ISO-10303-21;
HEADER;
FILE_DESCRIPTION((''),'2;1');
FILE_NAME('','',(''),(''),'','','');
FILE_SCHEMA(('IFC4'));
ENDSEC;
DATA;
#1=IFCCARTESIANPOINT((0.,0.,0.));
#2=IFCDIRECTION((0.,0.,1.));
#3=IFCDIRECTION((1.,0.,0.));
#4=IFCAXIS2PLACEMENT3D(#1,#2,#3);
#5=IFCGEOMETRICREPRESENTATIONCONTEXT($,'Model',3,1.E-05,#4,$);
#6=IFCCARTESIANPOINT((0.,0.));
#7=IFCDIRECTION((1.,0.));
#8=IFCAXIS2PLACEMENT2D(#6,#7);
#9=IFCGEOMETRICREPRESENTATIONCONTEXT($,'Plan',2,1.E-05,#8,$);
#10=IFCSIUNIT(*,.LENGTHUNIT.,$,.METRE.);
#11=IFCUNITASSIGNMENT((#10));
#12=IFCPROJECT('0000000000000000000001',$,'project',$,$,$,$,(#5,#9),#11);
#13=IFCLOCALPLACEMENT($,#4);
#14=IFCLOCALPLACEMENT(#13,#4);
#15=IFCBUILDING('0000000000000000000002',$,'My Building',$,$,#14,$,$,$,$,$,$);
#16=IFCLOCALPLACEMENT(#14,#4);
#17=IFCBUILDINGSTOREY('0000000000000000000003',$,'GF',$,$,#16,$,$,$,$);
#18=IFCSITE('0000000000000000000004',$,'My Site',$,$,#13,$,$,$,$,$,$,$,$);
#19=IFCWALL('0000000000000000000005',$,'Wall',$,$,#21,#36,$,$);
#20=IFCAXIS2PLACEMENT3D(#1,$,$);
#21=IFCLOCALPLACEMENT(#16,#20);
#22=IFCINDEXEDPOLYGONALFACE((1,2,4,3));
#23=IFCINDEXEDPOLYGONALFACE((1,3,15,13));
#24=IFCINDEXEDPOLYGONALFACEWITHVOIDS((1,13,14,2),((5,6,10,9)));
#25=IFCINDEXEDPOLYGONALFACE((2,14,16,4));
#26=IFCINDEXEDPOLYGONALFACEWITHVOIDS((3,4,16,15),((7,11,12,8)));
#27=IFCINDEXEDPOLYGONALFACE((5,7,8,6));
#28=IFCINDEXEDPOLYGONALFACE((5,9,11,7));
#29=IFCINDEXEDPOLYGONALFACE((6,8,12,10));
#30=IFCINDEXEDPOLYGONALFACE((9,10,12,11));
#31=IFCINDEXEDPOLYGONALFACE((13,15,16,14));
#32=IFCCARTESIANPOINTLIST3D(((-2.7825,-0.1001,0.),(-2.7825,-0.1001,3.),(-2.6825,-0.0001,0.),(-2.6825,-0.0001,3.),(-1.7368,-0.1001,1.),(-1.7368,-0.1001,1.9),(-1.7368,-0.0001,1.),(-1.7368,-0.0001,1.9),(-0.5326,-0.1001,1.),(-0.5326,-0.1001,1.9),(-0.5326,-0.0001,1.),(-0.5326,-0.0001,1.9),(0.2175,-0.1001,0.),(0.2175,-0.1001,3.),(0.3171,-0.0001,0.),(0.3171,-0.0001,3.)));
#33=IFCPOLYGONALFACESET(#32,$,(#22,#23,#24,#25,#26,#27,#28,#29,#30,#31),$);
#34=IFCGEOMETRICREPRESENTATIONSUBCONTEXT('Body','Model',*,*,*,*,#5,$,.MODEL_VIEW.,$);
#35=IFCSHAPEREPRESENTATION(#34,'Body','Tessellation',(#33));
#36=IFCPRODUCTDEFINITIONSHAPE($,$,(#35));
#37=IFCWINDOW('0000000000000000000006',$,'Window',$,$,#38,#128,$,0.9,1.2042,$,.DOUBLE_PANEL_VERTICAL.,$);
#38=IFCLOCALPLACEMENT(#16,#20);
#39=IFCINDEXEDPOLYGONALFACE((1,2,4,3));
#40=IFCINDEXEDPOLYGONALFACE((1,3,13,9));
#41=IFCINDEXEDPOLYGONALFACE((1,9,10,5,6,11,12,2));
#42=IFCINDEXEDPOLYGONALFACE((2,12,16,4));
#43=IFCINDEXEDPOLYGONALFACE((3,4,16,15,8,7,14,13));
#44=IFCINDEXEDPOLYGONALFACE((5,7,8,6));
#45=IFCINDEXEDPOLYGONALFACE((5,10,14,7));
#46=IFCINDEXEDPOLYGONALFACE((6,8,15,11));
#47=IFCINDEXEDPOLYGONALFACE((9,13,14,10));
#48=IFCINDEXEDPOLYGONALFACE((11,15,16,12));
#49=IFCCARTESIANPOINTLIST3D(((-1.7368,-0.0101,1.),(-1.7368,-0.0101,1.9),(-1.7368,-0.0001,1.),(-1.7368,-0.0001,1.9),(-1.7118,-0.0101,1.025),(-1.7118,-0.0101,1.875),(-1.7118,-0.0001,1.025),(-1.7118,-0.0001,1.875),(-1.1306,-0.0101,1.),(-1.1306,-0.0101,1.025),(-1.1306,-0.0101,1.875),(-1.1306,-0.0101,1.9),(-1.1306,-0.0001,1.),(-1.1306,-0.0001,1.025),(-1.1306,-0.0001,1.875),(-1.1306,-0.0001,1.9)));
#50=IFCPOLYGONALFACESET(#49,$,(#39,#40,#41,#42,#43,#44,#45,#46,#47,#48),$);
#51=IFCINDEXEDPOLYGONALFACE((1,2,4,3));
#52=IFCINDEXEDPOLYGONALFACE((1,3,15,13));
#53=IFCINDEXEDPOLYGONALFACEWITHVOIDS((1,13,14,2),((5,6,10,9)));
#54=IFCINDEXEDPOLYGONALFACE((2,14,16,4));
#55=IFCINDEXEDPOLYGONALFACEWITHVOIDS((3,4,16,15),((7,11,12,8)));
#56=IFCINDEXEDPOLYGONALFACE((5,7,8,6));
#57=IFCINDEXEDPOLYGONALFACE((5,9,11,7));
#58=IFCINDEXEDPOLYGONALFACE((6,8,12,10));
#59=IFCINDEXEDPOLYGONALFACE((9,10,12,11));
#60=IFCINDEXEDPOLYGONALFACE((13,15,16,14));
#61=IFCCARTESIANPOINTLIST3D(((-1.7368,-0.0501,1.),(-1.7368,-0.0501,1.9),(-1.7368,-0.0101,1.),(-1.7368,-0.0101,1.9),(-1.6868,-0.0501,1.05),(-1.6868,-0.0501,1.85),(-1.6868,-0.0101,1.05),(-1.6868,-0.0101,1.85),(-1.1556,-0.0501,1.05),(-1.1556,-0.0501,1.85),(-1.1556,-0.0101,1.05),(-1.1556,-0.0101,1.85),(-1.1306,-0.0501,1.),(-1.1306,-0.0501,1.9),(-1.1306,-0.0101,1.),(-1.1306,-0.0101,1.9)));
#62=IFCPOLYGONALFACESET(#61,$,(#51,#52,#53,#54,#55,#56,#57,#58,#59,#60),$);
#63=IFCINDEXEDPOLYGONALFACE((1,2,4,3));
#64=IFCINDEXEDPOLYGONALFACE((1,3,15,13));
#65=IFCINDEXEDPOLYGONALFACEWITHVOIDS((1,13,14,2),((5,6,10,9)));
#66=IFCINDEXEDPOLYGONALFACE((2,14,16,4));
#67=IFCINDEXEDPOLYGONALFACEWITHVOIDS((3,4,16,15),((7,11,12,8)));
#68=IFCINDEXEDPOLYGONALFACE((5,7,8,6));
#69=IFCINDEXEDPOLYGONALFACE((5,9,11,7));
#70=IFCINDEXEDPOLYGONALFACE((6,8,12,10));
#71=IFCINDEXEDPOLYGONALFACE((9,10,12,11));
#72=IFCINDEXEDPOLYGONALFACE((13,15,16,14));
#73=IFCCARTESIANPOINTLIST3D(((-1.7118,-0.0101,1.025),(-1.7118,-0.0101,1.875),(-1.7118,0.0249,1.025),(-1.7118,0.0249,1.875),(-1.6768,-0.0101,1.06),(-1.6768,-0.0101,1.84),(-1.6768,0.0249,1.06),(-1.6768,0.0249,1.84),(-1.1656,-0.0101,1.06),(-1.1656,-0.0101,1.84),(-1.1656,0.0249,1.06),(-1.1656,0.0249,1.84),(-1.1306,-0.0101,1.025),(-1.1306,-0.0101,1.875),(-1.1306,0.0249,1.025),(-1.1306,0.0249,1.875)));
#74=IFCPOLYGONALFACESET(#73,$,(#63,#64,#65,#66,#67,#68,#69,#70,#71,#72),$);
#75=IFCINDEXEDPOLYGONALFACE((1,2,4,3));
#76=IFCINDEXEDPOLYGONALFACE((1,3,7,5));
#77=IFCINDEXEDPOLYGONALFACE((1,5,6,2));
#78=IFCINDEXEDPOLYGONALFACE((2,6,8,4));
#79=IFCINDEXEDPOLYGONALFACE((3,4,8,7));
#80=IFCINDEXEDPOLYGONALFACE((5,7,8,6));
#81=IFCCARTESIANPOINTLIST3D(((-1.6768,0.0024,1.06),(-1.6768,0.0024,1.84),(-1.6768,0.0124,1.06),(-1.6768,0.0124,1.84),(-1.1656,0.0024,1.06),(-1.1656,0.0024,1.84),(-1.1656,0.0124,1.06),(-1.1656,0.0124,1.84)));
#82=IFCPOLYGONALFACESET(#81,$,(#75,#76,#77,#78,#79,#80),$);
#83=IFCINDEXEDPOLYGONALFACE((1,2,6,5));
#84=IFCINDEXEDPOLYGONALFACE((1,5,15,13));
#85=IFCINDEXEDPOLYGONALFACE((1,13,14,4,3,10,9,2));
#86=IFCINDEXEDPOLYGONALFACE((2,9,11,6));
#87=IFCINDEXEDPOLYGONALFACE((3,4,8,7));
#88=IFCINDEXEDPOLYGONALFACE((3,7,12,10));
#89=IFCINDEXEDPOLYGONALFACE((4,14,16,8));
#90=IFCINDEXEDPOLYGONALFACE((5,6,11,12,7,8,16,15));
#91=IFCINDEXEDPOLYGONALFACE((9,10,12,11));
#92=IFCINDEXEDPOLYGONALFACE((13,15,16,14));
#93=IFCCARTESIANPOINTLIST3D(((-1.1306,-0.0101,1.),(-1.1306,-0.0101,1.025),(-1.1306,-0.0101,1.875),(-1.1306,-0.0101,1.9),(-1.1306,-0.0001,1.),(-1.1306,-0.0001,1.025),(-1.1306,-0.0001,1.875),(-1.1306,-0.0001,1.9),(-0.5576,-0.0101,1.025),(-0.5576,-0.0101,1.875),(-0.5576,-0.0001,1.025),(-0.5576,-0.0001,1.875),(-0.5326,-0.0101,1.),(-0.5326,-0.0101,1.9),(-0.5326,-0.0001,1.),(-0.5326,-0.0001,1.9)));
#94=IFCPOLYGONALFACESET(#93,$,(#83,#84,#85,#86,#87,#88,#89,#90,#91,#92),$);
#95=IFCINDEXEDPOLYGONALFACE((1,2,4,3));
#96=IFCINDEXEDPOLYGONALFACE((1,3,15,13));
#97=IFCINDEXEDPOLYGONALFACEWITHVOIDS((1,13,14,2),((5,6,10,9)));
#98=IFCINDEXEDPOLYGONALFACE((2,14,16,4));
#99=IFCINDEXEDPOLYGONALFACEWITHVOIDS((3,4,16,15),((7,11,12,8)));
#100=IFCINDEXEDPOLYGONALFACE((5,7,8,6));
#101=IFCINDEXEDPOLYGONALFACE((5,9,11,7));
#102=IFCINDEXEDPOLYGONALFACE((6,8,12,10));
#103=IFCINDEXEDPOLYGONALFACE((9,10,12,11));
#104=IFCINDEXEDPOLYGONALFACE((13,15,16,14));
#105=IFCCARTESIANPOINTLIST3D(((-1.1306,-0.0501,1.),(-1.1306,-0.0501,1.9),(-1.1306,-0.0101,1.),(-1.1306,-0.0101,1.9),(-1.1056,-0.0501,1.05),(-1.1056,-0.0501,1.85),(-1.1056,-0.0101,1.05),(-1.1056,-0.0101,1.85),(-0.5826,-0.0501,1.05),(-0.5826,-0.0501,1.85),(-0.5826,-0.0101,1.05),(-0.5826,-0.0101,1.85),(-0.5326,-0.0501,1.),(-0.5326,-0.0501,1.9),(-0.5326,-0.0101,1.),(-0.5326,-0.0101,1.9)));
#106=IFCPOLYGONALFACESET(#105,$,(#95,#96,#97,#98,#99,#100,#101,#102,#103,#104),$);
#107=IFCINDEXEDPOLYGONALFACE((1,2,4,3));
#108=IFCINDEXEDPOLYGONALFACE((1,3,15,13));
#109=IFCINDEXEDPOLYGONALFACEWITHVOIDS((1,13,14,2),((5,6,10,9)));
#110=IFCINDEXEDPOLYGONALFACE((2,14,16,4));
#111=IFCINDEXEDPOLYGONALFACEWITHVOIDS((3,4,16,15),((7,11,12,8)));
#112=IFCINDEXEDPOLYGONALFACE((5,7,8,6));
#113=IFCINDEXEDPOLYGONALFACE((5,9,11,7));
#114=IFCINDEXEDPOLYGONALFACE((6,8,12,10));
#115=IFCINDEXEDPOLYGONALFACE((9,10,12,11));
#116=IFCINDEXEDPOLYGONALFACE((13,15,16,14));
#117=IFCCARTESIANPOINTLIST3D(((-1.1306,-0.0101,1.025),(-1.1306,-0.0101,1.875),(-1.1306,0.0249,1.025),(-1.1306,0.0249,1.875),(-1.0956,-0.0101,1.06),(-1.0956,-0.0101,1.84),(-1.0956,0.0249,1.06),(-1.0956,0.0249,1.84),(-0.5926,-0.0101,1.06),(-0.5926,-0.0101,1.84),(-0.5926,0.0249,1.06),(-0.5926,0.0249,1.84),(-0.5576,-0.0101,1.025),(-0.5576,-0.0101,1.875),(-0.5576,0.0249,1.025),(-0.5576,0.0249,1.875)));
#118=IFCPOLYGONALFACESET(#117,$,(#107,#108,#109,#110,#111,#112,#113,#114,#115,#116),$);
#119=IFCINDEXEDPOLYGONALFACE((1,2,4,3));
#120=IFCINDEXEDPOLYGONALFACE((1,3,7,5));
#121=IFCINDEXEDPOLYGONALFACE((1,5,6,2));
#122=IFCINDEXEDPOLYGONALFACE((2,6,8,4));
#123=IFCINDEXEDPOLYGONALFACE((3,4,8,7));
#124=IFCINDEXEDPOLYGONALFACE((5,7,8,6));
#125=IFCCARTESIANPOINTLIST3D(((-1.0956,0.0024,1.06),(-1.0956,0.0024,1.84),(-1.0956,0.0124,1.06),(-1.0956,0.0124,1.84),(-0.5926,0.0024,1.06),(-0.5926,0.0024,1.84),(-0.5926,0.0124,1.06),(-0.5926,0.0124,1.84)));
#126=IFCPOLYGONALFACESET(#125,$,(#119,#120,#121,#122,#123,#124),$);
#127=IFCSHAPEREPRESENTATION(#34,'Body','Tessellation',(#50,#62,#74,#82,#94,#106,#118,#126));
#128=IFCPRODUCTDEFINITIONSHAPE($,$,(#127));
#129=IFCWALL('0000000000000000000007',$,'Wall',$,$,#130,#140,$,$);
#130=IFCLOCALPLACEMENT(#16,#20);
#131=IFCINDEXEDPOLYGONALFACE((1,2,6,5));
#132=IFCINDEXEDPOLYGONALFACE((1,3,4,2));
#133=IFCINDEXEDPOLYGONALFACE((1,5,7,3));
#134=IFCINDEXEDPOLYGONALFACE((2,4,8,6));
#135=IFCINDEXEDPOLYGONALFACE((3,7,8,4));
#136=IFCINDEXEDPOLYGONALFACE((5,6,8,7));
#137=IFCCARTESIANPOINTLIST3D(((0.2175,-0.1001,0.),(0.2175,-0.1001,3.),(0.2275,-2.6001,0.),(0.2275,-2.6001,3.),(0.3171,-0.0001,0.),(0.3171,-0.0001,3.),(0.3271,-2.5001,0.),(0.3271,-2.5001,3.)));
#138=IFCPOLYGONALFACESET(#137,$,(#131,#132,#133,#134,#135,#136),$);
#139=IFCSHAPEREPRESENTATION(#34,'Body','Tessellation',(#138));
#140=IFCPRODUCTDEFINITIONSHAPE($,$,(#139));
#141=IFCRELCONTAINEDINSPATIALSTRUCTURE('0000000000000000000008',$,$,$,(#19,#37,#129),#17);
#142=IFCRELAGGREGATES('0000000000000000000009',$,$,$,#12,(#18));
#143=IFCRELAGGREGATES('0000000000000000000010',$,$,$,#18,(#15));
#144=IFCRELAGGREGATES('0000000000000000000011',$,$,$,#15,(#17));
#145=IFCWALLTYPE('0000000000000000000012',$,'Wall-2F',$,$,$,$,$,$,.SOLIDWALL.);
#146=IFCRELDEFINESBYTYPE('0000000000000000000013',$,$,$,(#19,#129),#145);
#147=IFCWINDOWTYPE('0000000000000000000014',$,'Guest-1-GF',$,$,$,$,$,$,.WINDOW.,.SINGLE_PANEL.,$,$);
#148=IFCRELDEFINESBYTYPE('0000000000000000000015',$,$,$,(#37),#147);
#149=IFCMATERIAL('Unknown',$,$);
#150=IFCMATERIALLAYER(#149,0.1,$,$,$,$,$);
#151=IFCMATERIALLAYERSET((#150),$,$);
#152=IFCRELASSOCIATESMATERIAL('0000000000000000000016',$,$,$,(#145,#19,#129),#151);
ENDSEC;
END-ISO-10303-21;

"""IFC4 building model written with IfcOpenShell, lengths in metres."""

from ifc_helpers import new_model, entity, si_unit, frame, origin_with_axes, origin_2d_with_axis, place, context, subcontext, project, spatial, line, indexed_curve, outline, extrude, shape, source, transform, mapped, material, layer, layer_set, layer_usage, type_object, type_shapes, element, fill, save


model = new_model("IFC4")

# Units and contexts
model_context = context("Model", 3, precision=1e-05, world=origin_with_axes())
plan_context = context("Plan", 2, precision=1e-05, world=origin_2d_with_axis())
body_context_1 = subcontext(model_context, "Body", "Model", "MODEL_VIEW")
body_context_2 = subcontext(plan_context, "Body", "Plan", "PLAN_VIEW")
ifc_project = project(units=[si_unit("LENGTHUNIT", "METRE")], contexts=[model_context, plan_context])

# Site, building, storey
site_placement = place(None, origin_with_axes())
site = spatial("IfcSite", under=ifc_project, at=site_placement, Name="My Site")
building_placement = place(site_placement, origin_with_axes())
building = spatial("IfcBuilding", under=site, at=building_placement, Name="My Building")
storey_placement = place(building_placement, origin_with_axes())
storey = spatial("IfcBuildingStorey", under=building, at=storey_placement, Name="GF")

# Shared definitions
ifc_material_1 = material(Name="Unknown")

# Shared definitions
ifc_layer_1 = layer(ifc_material_1, 0.1)
ifc_layer_set_1 = layer_set([ifc_layer_1])
wall_type = type_object("IfcWallType", Name="Wall-2F", PredefinedType="SOLIDWALL", material=ifc_layer_set_1)

# Wall, opening, window
ifc_layer_usage_1 = layer_usage(ifc_layer_set_1, "AXIS2", "POSITIVE", 0.0)
wall_1_placement = place(storey_placement, frame((-2.7825, -0.1001, 0.0), z_axis=(0.0, 0.0, 1.0), x_axis=(1.0, 0.0, 0.0)))
wall_1 = element("IfcWall", 1, at=wall_1_placement, inside=storey, type_object=wall_type, material=ifc_layer_usage_1, Name="Wall", context=body_context_1, shape_type="SweptSolid", body=[
    extrude(outline(indexed_curve([(0.0, 0.0), (0.1, 0.1), (3.0996, 0.1), (3.0, 0.0)], segments=[line(1, 2, 3, 4, 1)])), origin_with_axes(), (0.0, 0.0, 1.0), 3.0),
])
shared_shape_1 = source(origin_with_axes(), body_context_1, "Body", "SweptSolid", [
    extrude(outline(indexed_curve([(0.0, 0.0), (1.2042, 0.0), (1.2042, 0.9), (0.0, 0.9)], segments=[line(1, 2, 3, 4, 1)])), frame((0.0, -0.6, 0.0), z_axis=(0.0, -1.0, 0.0), x_axis=(1.0, 0.0, 0.0)), (0.0, 0.0, -1.0), 1.2),
])
opening_1_placement = place(wall_1_placement, frame((1.0457, 0.0, 1.0), z_axis=(0.0, 0.0, 1.0), x_axis=(1.0, 0.0, 0.0)))
opening_1 = element("IfcOpeningElement", 2, at=opening_1_placement, cuts=wall_1, PredefinedType="OPENING", context=body_context_1, shape_type="MappedRepresentation", body=[
    mapped(shared_shape_1, transform((0.0, 0.0, 0.0), x_axis=(1.0, 0.0, 0.0), y_axis=(0.0, 1.0, 0.0), z_axis=(0.0, 0.0, 1.0), scale=1.0)),
])
window_type_1 = type_object("IfcWindowType", Name="Guest-1-GF", PartitioningType="SINGLE_PANEL", PredefinedType="WINDOW")
shared_shape_2 = source(origin_with_axes(), body_context_1, "Body", "SweptSolid", [
    extrude(outline(indexed_curve([(0.6062, 0.0), (0.0, 0.0), (0.0, 0.9), (0.6062, 0.9), (0.6062, 0.875), (0.025, 0.875), (0.025, 0.025), (0.6062, 0.025)], segments=[line(1, 2, 3, 4, 5, 6, 7, 8, 1)])), frame((0.0, 0.09, 0.0), z_axis=(0.0, -1.0, 0.0), x_axis=(1.0, 0.0, 0.0)), (0.0, 0.0, -1.0), 0.01),
    extrude(outline(indexed_curve([(0.0, 0.0), (0.6062, 0.0), (0.6062, 0.9), (0.0, 0.9)], segments=[line(1, 2, 3, 4, 1)]), holes=[indexed_curve([(0.05, 0.05), (0.5812, 0.05), (0.5812, 0.85), (0.05, 0.85)], segments=[line(1, 2, 3, 4, 1)])]), frame((0.0, 0.05, 0.0), z_axis=(0.0, -1.0, 0.0), x_axis=(1.0, 0.0, 0.0)), (0.0, 0.0, -1.0), 0.04),
    extrude(outline(indexed_curve([(0.0, 0.0), (0.5812, 0.0), (0.5812, 0.85), (0.0, 0.85)], segments=[line(1, 2, 3, 4, 1)]), holes=[indexed_curve([(0.035, 0.035), (0.5462, 0.035), (0.5462, 0.815), (0.035, 0.815)], segments=[line(1, 2, 3, 4, 1)])]), frame((0.025, 0.09, 0.025), z_axis=(0.0, -1.0, 0.0), x_axis=(1.0, 0.0, 0.0)), (0.0, 0.0, -1.0), 0.035),
    extrude(outline(indexed_curve([(0.035, 0.035), (0.5462, 0.035), (0.5462, 0.815), (0.035, 0.815)], segments=[line(1, 2, 3, 4, 1)])), frame((0.025, 0.1025, 0.025), z_axis=(0.0, -1.0, 0.0), x_axis=(1.0, 0.0, 0.0)), (0.0, 0.0, -1.0), 0.01),
    extrude(outline(indexed_curve([(0.0, 0.9), (0.598, 0.9), (0.598, 0.0), (0.0, 0.0), (0.0, 0.025), (0.573, 0.025), (0.573, 0.875), (0.0, 0.875)], segments=[line(1, 2, 3, 4, 5, 6, 7, 8, 1)])), frame((0.6062, 0.09, 0.0), z_axis=(0.0, -1.0, 0.0), x_axis=(1.0, 0.0, 0.0)), (0.0, 0.0, -1.0), 0.01),
    extrude(outline(indexed_curve([(0.0, 0.0), (0.598, 0.0), (0.598, 0.9), (0.0, 0.9)], segments=[line(1, 2, 3, 4, 1)]), holes=[indexed_curve([(0.025, 0.05), (0.548, 0.05), (0.548, 0.85), (0.025, 0.85)], segments=[line(1, 2, 3, 4, 1)])]), frame((0.6062, 0.05, 0.0), z_axis=(0.0, -1.0, 0.0), x_axis=(1.0, 0.0, 0.0)), (0.0, 0.0, -1.0), 0.04),
    extrude(outline(indexed_curve([(0.0, 0.0), (0.573, 0.0), (0.573, 0.85), (0.0, 0.85)], segments=[line(1, 2, 3, 4, 1)]), holes=[indexed_curve([(0.035, 0.035), (0.538, 0.035), (0.538, 0.815), (0.035, 0.815)], segments=[line(1, 2, 3, 4, 1)])]), frame((0.6062, 0.09, 0.025), z_axis=(0.0, -1.0, 0.0), x_axis=(1.0, 0.0, 0.0)), (0.0, 0.0, -1.0), 0.035),
    extrude(outline(indexed_curve([(0.035, 0.035), (0.538, 0.035), (0.538, 0.815), (0.035, 0.815)], segments=[line(1, 2, 3, 4, 1)])), frame((0.6062, 0.1025, 0.025), z_axis=(0.0, -1.0, 0.0), x_axis=(1.0, 0.0, 0.0)), (0.0, 0.0, -1.0), 0.01),
])
shared_shape_3 = source(origin_with_axes(), body_context_2, "Body", "Curve2D", [
    entity("IfcIndexedPolyCurve", entity("IfcCartesianPointList2D", [[0.05, 0.05], [0.5812, 0.05]])),
    entity("IfcIndexedPolyCurve", entity("IfcCartesianPointList2D", [[0.0, 0.1], [0.025, 0.1], [0.025, 0.09], [0.05, 0.09], [0.05, 0.05], [0.0, 0.05]]), [entity("IfcLineIndex", [1, 2, 3, 4, 5, 6, 1])]),
    entity("IfcIndexedPolyCurve", entity("IfcCartesianPointList2D", [[0.6062, 0.1], [0.6062, 0.1], [0.6062, 0.09], [0.5812, 0.09], [0.5812, 0.05], [0.6062, 0.05]])),
    entity("IfcIndexedPolyCurve", entity("IfcCartesianPointList2D", [[0.025, 0.09], [0.06, 0.09], [0.06, 0.125], [0.025, 0.125]]), [entity("IfcLineIndex", [1, 2, 3, 4, 1])]),
    entity("IfcIndexedPolyCurve", entity("IfcCartesianPointList2D", [[0.6062, 0.09], [0.5712, 0.09], [0.5712, 0.125], [0.6062, 0.125]]), [entity("IfcLineIndex", [1, 2, 3, 4, 1])]),
    entity("IfcIndexedPolyCurve", entity("IfcCartesianPointList2D", [[0.06, 0.09], [0.5712, 0.09]])),
    entity("IfcIndexedPolyCurve", entity("IfcCartesianPointList2D", [[0.06, 0.125], [0.5712, 0.125]])),
    entity("IfcIndexedPolyCurve", entity("IfcCartesianPointList2D", [[0.06, 0.1075], [0.5712, 0.1075]])),
    entity("IfcIndexedPolyCurve", entity("IfcCartesianPointList2D", [[0.6312, 0.05], [1.1542, 0.05]])),
    entity("IfcIndexedPolyCurve", entity("IfcCartesianPointList2D", [[0.6062, 0.1], [0.6062, 0.1], [0.6062, 0.09], [0.6312, 0.09], [0.6312, 0.05], [0.6062, 0.05]])),
    entity("IfcIndexedPolyCurve", entity("IfcCartesianPointList2D", [[1.2042, 0.1], [1.1792, 0.1], [1.1792, 0.09], [1.1542, 0.09], [1.1542, 0.05], [1.2042, 0.05]]), [entity("IfcLineIndex", [1, 2, 3, 4, 5, 6, 1])]),
    entity("IfcIndexedPolyCurve", entity("IfcCartesianPointList2D", [[0.6062, 0.09], [0.6412, 0.09], [0.6412, 0.125], [0.6062, 0.125]]), [entity("IfcLineIndex", [1, 2, 3, 4, 1])]),
    entity("IfcIndexedPolyCurve", entity("IfcCartesianPointList2D", [[1.1792, 0.09], [1.1442, 0.09], [1.1442, 0.125], [1.1792, 0.125]]), [entity("IfcLineIndex", [1, 2, 3, 4, 1])]),
    entity("IfcIndexedPolyCurve", entity("IfcCartesianPointList2D", [[0.6412, 0.09], [1.1442, 0.09]])),
    entity("IfcIndexedPolyCurve", entity("IfcCartesianPointList2D", [[0.6412, 0.125], [1.1442, 0.125]])),
    entity("IfcIndexedPolyCurve", entity("IfcCartesianPointList2D", [[0.6412, 0.1075], [1.1442, 0.1075]])),
])
type_shapes(window_type_1, [shared_shape_2, shared_shape_3])
window_1_placement = place(opening_1_placement, frame((0.0, 0.0, 0.0), z_axis=(0.0, 0.0, 1.0), x_axis=(1.0, 0.0, 0.0)))
window_1 = element("IfcWindow", 3, at=window_1_placement, inside=storey, type_object=window_type_1, Name="Window", OverallHeight=0.9, OverallWidth=1.2042, PartitioningType="DOUBLE_PANEL_VERTICAL", shapes=[
    shape(body_context_1, "Body", "MappedRepresentation", [mapped(shared_shape_2, transform((0.0, 0.0, 0.0), x_axis=(1.0, 0.0, 0.0), y_axis=(0.0, 1.0, 0.0), z_axis=(0.0, 0.0, 1.0), scale=1.0))]),
    shape(body_context_2, "Body", "MappedRepresentation", [mapped(shared_shape_3, transform((0.0, 0.0, 0.0), x_axis=(1.0, 0.0, 0.0), y_axis=(0.0, 1.0, 0.0), z_axis=(0.0, 0.0, 1.0), scale=1.0))]),
])
fill(opening_1, window_1)

# Wall
ifc_layer_usage_2 = layer_usage(ifc_layer_set_1, "AXIS2", "POSITIVE", 0.0)
wall_2_placement = place(storey_placement, frame((0.2175, -0.1001, 0.0), z_axis=(0.0, 0.0, 1.0), x_axis=(0.004, -0.999992, 0.0)))
element("IfcWall", 4, at=wall_2_placement, inside=storey, type_object=wall_type, material=ifc_layer_usage_2, Name="Wall", context=body_context_1, shape_type="SweptSolid", body=[
    extrude(outline(indexed_curve([(0.0, 0.0), (-0.0996, 0.1), (2.4004, 0.1), (2.5, 0.0)], segments=[line(1, 2, 3, 4, 1)])), origin_with_axes(), (0.0, 0.0, 1.0), 3.0),
])

save(model, "model.ifc")
